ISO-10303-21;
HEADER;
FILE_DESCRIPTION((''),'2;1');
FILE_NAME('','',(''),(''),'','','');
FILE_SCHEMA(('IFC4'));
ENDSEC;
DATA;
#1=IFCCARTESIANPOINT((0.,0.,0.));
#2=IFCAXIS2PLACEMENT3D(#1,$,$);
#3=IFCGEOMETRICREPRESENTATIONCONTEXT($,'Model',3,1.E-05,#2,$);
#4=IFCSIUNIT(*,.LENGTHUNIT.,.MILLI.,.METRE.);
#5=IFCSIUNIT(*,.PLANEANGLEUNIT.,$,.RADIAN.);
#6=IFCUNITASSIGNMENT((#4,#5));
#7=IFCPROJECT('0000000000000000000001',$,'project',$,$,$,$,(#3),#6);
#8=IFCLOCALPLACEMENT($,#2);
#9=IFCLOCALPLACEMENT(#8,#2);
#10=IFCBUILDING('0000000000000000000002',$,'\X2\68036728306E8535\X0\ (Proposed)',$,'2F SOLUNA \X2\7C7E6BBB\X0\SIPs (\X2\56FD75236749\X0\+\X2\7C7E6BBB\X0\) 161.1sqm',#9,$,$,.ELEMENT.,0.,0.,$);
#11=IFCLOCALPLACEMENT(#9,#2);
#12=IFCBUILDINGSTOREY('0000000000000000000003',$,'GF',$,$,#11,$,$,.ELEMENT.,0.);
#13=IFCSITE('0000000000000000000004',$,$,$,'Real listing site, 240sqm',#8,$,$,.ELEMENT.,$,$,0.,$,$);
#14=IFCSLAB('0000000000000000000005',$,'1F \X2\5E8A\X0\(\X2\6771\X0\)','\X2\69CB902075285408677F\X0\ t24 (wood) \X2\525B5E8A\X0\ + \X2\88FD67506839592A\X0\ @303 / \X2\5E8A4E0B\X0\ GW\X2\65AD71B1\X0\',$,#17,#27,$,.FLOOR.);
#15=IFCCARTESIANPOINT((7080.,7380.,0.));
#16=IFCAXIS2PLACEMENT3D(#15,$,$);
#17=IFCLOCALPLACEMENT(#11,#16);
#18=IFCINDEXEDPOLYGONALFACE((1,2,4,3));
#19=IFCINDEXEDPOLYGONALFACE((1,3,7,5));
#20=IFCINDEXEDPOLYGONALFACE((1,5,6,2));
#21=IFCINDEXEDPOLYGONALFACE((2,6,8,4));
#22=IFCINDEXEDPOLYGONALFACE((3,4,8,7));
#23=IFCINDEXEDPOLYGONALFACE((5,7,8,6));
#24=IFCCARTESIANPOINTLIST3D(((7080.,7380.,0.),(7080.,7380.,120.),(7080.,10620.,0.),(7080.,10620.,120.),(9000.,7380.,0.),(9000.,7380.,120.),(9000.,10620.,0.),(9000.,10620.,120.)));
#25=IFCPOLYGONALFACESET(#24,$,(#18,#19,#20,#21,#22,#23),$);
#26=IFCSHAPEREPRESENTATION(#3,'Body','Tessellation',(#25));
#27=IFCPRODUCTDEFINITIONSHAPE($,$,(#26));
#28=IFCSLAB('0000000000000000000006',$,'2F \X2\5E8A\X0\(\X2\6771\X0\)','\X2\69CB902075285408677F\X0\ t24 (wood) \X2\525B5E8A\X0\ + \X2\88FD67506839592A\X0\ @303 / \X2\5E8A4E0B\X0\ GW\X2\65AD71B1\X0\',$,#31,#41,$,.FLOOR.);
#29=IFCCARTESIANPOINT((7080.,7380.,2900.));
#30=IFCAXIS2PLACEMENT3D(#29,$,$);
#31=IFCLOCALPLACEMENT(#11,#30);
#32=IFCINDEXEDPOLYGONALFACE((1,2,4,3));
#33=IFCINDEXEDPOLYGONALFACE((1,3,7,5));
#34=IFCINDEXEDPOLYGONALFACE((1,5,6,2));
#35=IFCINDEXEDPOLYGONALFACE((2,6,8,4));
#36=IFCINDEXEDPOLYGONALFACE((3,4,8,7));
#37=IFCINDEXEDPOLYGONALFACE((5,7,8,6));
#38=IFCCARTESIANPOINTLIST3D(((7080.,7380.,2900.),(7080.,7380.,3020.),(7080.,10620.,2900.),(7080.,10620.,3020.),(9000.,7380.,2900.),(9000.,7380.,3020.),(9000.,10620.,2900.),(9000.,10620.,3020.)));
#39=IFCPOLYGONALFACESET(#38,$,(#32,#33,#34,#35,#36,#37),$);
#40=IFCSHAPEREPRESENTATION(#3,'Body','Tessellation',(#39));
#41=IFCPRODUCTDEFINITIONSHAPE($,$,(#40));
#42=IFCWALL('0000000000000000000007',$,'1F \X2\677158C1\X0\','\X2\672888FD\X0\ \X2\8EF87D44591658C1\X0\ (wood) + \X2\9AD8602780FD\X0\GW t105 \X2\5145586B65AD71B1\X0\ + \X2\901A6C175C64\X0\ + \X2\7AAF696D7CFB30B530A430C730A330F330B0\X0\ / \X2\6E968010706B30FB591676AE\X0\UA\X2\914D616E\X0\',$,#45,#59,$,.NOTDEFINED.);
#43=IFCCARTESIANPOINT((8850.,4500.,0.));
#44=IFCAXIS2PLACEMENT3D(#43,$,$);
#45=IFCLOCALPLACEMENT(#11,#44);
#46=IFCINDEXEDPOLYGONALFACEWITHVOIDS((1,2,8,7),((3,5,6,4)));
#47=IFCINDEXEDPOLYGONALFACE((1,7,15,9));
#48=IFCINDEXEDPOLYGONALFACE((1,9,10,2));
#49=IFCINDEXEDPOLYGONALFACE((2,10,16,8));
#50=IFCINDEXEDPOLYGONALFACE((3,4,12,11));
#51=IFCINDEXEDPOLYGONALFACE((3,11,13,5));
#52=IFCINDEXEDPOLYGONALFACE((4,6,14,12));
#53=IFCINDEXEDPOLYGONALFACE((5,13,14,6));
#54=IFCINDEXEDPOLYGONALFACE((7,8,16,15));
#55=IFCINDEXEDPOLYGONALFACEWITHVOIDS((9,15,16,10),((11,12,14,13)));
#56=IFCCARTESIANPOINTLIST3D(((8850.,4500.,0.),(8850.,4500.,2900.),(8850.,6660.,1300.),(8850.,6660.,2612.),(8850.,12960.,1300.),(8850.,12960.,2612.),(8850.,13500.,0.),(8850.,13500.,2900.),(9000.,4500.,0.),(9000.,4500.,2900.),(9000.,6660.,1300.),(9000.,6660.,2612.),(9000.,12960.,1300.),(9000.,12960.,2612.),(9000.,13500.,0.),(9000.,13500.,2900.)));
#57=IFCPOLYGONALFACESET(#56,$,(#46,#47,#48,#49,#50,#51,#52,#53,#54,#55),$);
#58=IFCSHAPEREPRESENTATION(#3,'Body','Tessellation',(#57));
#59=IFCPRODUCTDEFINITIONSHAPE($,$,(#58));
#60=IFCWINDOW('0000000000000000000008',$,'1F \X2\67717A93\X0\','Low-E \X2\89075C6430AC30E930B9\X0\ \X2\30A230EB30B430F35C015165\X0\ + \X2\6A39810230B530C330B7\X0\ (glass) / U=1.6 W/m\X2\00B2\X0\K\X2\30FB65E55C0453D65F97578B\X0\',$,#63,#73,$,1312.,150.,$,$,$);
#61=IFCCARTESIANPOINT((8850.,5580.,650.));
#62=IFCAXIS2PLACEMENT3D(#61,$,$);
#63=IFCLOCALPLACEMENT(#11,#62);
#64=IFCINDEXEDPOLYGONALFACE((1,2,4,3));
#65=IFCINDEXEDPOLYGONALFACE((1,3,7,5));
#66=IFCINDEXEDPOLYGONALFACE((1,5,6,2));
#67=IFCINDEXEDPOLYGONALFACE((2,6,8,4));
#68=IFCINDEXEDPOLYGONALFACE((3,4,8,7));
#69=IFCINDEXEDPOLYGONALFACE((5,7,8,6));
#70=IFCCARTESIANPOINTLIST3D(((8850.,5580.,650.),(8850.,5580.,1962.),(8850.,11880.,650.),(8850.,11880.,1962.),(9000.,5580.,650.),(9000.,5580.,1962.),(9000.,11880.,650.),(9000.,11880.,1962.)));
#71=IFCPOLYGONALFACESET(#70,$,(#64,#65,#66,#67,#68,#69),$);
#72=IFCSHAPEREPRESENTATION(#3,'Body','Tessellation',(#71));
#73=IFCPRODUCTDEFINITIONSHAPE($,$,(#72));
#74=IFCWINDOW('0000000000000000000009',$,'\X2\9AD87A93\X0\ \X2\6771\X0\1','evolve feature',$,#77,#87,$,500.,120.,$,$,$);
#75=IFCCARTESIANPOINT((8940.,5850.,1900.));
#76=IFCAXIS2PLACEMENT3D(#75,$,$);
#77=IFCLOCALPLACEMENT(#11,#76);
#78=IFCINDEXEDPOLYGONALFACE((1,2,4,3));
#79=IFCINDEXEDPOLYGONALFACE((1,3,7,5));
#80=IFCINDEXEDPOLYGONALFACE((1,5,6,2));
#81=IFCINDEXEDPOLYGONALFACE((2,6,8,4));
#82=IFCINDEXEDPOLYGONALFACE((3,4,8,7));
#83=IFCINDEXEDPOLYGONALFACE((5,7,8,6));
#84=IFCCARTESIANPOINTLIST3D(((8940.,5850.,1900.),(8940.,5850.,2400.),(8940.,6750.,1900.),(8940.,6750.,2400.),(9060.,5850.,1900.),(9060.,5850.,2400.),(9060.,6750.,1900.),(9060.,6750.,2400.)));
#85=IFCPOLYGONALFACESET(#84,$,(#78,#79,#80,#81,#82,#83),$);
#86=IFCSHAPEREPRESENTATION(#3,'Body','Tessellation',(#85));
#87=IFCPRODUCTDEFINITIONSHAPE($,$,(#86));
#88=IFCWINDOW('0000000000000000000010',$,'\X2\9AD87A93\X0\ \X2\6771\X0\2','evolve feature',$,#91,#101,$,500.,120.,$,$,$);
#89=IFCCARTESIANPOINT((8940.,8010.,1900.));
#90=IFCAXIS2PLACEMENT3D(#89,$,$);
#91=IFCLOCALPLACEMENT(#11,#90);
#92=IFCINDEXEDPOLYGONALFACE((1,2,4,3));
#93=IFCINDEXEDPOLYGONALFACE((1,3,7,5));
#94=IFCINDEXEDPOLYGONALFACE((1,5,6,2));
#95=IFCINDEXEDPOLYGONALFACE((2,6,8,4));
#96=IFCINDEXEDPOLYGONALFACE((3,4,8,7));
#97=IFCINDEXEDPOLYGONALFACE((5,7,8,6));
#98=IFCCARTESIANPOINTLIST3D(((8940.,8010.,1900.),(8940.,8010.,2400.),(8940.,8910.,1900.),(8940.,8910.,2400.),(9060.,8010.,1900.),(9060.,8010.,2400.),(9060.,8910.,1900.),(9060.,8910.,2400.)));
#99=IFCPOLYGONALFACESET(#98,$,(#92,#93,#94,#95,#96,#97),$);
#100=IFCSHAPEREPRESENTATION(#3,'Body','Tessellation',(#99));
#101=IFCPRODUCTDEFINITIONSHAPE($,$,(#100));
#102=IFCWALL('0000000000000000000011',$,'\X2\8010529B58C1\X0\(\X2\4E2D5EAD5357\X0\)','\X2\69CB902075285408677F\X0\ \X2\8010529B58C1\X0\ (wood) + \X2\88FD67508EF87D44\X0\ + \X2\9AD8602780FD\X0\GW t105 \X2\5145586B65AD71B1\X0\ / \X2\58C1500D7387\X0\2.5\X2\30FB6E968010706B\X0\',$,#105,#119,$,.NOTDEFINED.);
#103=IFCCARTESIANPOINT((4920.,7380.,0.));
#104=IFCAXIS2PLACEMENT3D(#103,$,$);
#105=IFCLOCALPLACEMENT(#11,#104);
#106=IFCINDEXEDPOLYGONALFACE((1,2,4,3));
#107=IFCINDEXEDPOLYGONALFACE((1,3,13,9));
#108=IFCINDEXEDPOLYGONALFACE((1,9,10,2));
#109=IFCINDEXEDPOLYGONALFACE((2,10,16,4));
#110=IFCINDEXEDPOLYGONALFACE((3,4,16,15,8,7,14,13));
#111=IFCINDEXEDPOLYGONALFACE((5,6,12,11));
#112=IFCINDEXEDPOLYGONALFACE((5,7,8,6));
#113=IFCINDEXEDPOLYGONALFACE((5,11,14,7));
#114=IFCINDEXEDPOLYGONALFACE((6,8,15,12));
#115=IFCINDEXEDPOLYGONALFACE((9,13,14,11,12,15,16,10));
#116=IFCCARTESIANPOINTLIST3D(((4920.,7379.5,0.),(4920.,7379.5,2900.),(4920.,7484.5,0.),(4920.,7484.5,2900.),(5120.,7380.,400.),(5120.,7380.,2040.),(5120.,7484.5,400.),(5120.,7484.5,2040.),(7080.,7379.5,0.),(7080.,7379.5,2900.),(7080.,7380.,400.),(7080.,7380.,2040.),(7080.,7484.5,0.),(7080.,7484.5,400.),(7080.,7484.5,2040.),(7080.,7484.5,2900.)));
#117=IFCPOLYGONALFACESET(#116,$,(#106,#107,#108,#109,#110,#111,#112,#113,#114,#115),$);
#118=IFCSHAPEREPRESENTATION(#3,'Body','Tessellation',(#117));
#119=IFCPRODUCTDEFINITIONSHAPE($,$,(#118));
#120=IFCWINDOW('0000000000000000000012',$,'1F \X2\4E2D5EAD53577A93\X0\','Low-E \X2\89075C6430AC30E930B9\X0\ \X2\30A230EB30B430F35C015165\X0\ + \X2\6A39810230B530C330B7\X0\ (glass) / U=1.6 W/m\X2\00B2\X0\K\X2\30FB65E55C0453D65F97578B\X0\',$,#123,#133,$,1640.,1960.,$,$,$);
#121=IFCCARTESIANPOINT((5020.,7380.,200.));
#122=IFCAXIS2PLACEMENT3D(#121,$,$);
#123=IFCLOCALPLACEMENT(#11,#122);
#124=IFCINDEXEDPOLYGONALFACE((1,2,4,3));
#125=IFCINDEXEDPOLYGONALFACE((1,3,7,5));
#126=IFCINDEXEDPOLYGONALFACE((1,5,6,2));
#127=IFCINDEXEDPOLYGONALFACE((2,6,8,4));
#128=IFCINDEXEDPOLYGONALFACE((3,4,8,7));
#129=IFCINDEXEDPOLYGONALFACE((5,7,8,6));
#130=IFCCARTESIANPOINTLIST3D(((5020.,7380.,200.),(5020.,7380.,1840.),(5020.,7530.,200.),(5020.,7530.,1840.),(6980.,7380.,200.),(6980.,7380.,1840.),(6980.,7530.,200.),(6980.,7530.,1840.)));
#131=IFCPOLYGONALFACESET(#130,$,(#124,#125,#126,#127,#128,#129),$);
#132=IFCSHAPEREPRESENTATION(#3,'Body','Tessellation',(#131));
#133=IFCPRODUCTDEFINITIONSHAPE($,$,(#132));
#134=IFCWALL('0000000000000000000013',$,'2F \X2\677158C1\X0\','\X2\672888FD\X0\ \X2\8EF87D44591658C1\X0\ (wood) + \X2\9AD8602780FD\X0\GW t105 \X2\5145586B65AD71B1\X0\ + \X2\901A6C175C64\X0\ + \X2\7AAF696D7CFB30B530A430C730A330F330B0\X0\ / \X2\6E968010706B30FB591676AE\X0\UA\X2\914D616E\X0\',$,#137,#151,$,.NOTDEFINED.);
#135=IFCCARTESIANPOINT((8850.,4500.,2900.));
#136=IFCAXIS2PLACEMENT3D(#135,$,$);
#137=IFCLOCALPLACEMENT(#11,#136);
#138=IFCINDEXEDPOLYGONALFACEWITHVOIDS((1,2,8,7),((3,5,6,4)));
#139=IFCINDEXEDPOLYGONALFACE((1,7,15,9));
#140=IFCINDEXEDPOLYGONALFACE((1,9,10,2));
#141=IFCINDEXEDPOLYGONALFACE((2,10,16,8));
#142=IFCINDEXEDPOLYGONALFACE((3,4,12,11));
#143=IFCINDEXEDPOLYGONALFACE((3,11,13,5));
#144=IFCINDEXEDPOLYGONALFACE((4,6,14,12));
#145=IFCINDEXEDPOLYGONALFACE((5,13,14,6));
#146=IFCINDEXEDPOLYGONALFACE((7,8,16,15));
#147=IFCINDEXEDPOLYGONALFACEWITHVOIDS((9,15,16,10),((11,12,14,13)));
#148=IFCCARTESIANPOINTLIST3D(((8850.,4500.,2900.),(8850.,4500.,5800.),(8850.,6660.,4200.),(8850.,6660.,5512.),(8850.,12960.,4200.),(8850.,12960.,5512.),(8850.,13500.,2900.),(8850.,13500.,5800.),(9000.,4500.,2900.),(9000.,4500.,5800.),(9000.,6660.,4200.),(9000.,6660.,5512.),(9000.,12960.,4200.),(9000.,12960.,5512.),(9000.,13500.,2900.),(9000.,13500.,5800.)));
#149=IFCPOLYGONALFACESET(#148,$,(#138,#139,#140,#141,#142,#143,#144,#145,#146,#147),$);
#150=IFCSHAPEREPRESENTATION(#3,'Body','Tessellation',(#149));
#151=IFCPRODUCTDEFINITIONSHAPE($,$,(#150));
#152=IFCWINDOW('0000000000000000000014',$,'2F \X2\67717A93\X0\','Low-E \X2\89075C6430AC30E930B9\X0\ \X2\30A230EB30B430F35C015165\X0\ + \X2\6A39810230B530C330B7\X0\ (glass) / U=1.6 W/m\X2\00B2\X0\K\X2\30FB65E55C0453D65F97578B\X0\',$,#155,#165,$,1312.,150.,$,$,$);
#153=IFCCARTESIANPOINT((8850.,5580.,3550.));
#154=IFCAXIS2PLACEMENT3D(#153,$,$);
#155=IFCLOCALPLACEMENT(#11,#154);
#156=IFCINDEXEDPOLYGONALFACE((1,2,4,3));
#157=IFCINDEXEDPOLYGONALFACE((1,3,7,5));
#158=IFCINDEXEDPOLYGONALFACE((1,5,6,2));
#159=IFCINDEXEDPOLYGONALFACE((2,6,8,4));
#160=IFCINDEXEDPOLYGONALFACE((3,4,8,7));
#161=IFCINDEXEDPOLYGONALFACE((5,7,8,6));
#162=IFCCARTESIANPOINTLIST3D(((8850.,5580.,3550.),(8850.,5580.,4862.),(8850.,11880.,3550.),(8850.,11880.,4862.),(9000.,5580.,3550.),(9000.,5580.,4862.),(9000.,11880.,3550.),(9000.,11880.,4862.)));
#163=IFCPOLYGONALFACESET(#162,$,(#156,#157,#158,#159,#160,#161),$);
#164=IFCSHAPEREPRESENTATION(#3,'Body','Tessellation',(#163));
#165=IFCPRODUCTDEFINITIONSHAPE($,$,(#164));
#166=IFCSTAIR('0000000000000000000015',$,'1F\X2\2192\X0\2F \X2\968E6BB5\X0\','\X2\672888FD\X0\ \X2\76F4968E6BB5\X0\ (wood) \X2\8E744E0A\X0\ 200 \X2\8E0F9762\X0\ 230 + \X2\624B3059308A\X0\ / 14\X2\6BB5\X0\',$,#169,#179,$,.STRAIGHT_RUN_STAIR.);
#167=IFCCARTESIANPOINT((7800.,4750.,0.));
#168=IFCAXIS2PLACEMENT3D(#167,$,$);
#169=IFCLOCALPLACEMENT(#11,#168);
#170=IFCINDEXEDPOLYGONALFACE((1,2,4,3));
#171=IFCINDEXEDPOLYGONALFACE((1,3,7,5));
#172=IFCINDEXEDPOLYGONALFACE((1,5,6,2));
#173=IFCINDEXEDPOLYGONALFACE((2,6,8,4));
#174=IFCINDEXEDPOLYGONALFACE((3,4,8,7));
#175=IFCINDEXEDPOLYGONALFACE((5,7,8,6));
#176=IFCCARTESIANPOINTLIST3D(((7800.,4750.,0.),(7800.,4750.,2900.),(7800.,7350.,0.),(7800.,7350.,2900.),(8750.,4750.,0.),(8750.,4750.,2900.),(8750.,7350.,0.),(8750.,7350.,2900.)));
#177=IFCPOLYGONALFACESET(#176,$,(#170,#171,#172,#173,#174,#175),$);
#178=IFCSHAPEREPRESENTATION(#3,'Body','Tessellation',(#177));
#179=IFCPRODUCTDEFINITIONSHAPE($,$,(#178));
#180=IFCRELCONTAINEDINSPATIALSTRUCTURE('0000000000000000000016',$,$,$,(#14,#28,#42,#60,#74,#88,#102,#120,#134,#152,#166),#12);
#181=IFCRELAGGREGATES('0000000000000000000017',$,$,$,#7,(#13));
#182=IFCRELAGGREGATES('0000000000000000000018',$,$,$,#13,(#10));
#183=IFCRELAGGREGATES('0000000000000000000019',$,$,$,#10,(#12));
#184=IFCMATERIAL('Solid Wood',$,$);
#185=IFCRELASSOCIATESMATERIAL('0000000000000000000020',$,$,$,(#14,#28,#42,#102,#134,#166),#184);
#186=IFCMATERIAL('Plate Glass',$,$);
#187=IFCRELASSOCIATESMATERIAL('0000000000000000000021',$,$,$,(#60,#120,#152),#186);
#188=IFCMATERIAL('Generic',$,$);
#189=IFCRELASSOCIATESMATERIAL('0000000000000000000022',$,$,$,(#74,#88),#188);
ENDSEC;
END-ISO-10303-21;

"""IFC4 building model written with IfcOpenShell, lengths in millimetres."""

from ifc_helpers import new_model, si_unit, frame, frame_2d, origin, place, context, project, spatial, rectangle, extrude, material, element, fill, save


model = new_model("IFC4")

# Units and contexts
model_context = context("Model", 3, precision=1e-05, world=origin())
ifc_project = project(units=[si_unit("LENGTHUNIT", "METRE", prefix="MILLI"), si_unit("PLANEANGLEUNIT", "RADIAN")], contexts=[model_context])

# Site, building, storey
site_placement = place(None, origin())
site = spatial("IfcSite", under=ifc_project, at=site_placement, ObjectType="Real listing site, 240sqm", CompositionType="ELEMENT", RefElevation=0.0)
building_placement = place(site_placement, origin())
building = spatial("IfcBuilding", under=site, at=building_placement, Name="栃木の蔵 (Proposed)", ObjectType="2F SOLUNA 籾殻SIPs (国産杉+籾殻) 161.1sqm", CompositionType="ELEMENT", ElevationOfRefHeight=0.0, ElevationOfTerrain=0.0)
storey_placement = place(building_placement, origin())
storey = spatial("IfcBuildingStorey", under=building, at=storey_placement, Name="GF", CompositionType="ELEMENT", Elevation=0.0)

# Slabs
ifc_material_1 = material(Name="Solid Wood")
slab_1_placement = place(storey_placement, frame((7080.0, 7380.0, 0.0)))
element("IfcSlab", 1, at=slab_1_placement, inside=storey, material=ifc_material_1, Name="1F 床(東)", Description="構造用合板 t24 (wood) 剛床 + 製材根太 @303 / 床下 GW断熱", PredefinedType="FLOOR", context=model_context, shape_type="SweptSolid", body=[
    extrude(rectangle(XDim=1920.0, YDim=3240.0, at=frame_2d((960.0, 1620.0))), frame((7080.0, 7380.0, 0.0)), (0.0, 0.0, 1.0), 120.0),
])
slab_2_placement = place(storey_placement, frame((7080.0, 7380.0, 2900.0)))
element("IfcSlab", 2, at=slab_2_placement, inside=storey, material=ifc_material_1, Name="2F 床(東)", Description="構造用合板 t24 (wood) 剛床 + 製材根太 @303 / 床下 GW断熱", PredefinedType="FLOOR", context=model_context, shape_type="SweptSolid", body=[
    extrude(rectangle(XDim=1920.0, YDim=3240.0, at=frame_2d((960.0, 1620.0))), frame((7080.0, 7380.0, 2900.0)), (0.0, 0.0, 1.0), 120.0),
])

# Wall, openings, windows
wall_1_placement = place(storey_placement, frame((8850.0, 4500.0, 0.0)))
wall_1 = element("IfcWall", 3, at=wall_1_placement, inside=storey, material=ifc_material_1, Name="1F 東壁", Description="木製 軸組外壁 (wood) + 高性能GW t105 充填断熱 + 通気層 + 窯業系サイディング / 準耐火・外皮UA配慮", PredefinedType="NOTDEFINED", context=model_context, shape_type="SweptSolid", body=[
    extrude(rectangle(XDim=150.0, YDim=9000.0, at=frame_2d((75.0, 4500.0))), frame((8850.0, 4500.0, 0.0)), (0.0, 0.0, 1.0), 2900.0),
])
opening_1_placement = place(storey_placement, frame((8850.0, 5580.0, 650.0)))
opening_1 = element("IfcOpeningElement", 4, at=opening_1_placement, cuts=wall_1, PredefinedType="NOTDEFINED", context=model_context, shape_type="SweptSolid", body=[
    extrude(rectangle(XDim=150.0, YDim=6300.0, at=frame_2d((75.0, 3150.0))), frame((8850.0, 5580.0, 650.0)), (0.0, 0.0, 1.0), 1312.0),
])
opening_2_placement = place(storey_placement, frame((8940.0, 5850.0, 1900.0)))
opening_2 = element("IfcOpeningElement", 5, at=opening_2_placement, cuts=wall_1, PredefinedType="NOTDEFINED", context=model_context, shape_type="SweptSolid", body=[
    extrude(rectangle(XDim=120.0, YDim=900.0, at=frame_2d((60.0, 450.0))), frame((8940.0, 5850.0, 1900.0)), (0.0, 0.0, 1.0), 500.0),
])
opening_3_placement = place(storey_placement, frame((8940.0, 8010.0, 1900.0)))
opening_3 = element("IfcOpeningElement", 6, at=opening_3_placement, cuts=wall_1, PredefinedType="NOTDEFINED", context=model_context, shape_type="SweptSolid", body=[
    extrude(rectangle(XDim=120.0, YDim=900.0, at=frame_2d((60.0, 450.0))), frame((8940.0, 8010.0, 1900.0)), (0.0, 0.0, 1.0), 500.0),
])
ifc_material_2 = material(Name="Plate Glass")
window_1_placement = place(storey_placement, frame((8850.0, 5580.0, 650.0)))
window_1 = element("IfcWindow", 7, at=window_1_placement, inside=storey, material=ifc_material_2, Name="1F 東窓", Description="Low-E 複層ガラス アルゴン封入 + 樹脂サッシ (glass) / U=1.6 W/m²K・日射取得型", OverallHeight=1312.0, OverallWidth=150.0, context=model_context, shape_type="SweptSolid", body=[
    extrude(rectangle(XDim=150.0, YDim=6300.0, at=frame_2d((75.0, 3150.0))), frame((8850.0, 5580.0, 650.0)), (0.0, 0.0, 1.0), 1312.0),
])
fill(opening_1, window_1)
ifc_material_3 = material(Name="Generic")
window_2_placement = place(storey_placement, frame((8940.0, 5850.0, 1900.0)))
window_2 = element("IfcWindow", 8, at=window_2_placement, inside=storey, material=ifc_material_3, Name="高窓 東1", Description="evolve feature", OverallHeight=500.0, OverallWidth=120.0, context=model_context, shape_type="SweptSolid", body=[
    extrude(rectangle(XDim=120.0, YDim=900.0, at=frame_2d((60.0, 450.0))), frame((8940.0, 5850.0, 1900.0)), (0.0, 0.0, 1.0), 500.0),
])
fill(opening_2, window_2)
window_3_placement = place(storey_placement, frame((8940.0, 8010.0, 1900.0)))
window_3 = element("IfcWindow", 9, at=window_3_placement, inside=storey, material=ifc_material_3, Name="高窓 東2", Description="evolve feature", OverallHeight=500.0, OverallWidth=120.0, context=model_context, shape_type="SweptSolid", body=[
    extrude(rectangle(XDim=120.0, YDim=900.0, at=frame_2d((60.0, 450.0))), frame((8940.0, 8010.0, 1900.0)), (0.0, 0.0, 1.0), 500.0),
])
fill(opening_3, window_3)

# Wall, opening, window
wall_2_placement = place(storey_placement, frame((4920.0, 7380.0, 0.0)))
wall_2 = element("IfcWall", 10, at=wall_2_placement, inside=storey, material=ifc_material_1, Name="耐力壁(中庭南)", Description="構造用合板 耐力壁 (wood) + 製材軸組 + 高性能GW t105 充填断熱 / 壁倍率2.5・準耐火", PredefinedType="NOTDEFINED", context=model_context, shape_type="SweptSolid", body=[
    extrude(rectangle(XDim=2160.0, YDim=105.0, at=frame_2d((1080.0, 52.0))), frame((4920.0, 7380.0, 0.0)), (0.0, 0.0, 1.0), 2900.0),
])
opening_4_placement = place(storey_placement, frame((5020.0, 7380.0, 200.0)))
opening_4 = element("IfcOpeningElement", 11, at=opening_4_placement, cuts=wall_2, PredefinedType="NOTDEFINED", context=model_context, shape_type="SweptSolid", body=[
    extrude(rectangle(XDim=1960.0, YDim=150.0, at=frame_2d((980.0, 75.0))), frame((5020.0, 7380.0, 200.0)), (0.0, 0.0, 1.0), 1640.0),
])
window_4_placement = place(storey_placement, frame((5020.0, 7380.0, 200.0)))
window_4 = element("IfcWindow", 12, at=window_4_placement, inside=storey, material=ifc_material_2, Name="1F 中庭南窓", Description="Low-E 複層ガラス アルゴン封入 + 樹脂サッシ (glass) / U=1.6 W/m²K・日射取得型", OverallHeight=1640.0, OverallWidth=1960.0, context=model_context, shape_type="SweptSolid", body=[
    extrude(rectangle(XDim=1960.0, YDim=150.0, at=frame_2d((980.0, 75.0))), frame((5020.0, 7380.0, 200.0)), (0.0, 0.0, 1.0), 1640.0),
])
fill(opening_4, window_4)

# Wall, opening, window
wall_3_placement = place(storey_placement, frame((8850.0, 4500.0, 2900.0)))
wall_3 = element("IfcWall", 13, at=wall_3_placement, inside=storey, material=ifc_material_1, Name="2F 東壁", Description="木製 軸組外壁 (wood) + 高性能GW t105 充填断熱 + 通気層 + 窯業系サイディング / 準耐火・外皮UA配慮", PredefinedType="NOTDEFINED", context=model_context, shape_type="SweptSolid", body=[
    extrude(rectangle(XDim=150.0, YDim=9000.0, at=frame_2d((75.0, 4500.0))), frame((8850.0, 4500.0, 2900.0)), (0.0, 0.0, 1.0), 2900.0),
])
opening_5_placement = place(storey_placement, frame((8850.0, 5580.0, 3550.0)))
opening_5 = element("IfcOpeningElement", 14, at=opening_5_placement, cuts=wall_3, PredefinedType="NOTDEFINED", context=model_context, shape_type="SweptSolid", body=[
    extrude(rectangle(XDim=150.0, YDim=6300.0, at=frame_2d((75.0, 3150.0))), frame((8850.0, 5580.0, 3550.0)), (0.0, 0.0, 1.0), 1312.0),
])
window_5_placement = place(storey_placement, frame((8850.0, 5580.0, 3550.0)))
window_5 = element("IfcWindow", 15, at=window_5_placement, inside=storey, material=ifc_material_2, Name="2F 東窓", Description="Low-E 複層ガラス アルゴン封入 + 樹脂サッシ (glass) / U=1.6 W/m²K・日射取得型", OverallHeight=1312.0, OverallWidth=150.0, context=model_context, shape_type="SweptSolid", body=[
    extrude(rectangle(XDim=150.0, YDim=6300.0, at=frame_2d((75.0, 3150.0))), frame((8850.0, 5580.0, 3550.0)), (0.0, 0.0, 1.0), 1312.0),
])
fill(opening_5, window_5)

# Stair
stair_placement = place(storey_placement, frame((7800.0, 4750.0, 0.0)))
element("IfcStair", 16, at=stair_placement, inside=storey, material=ifc_material_1, Name="1F→2F 階段", Description="木製 直階段 (wood) 蹴上 200 踏面 230 + 手すり / 14段", PredefinedType="STRAIGHT_RUN_STAIR", context=model_context, shape_type="SweptSolid", body=[
    extrude(rectangle(XDim=950.0, YDim=2600.0, at=frame_2d((475.0, 1300.0))), frame((7800.0, 4750.0, 0.0)), (0.0, 0.0, 1.0), 2900.0),
])

save(model, "model.ifc")
